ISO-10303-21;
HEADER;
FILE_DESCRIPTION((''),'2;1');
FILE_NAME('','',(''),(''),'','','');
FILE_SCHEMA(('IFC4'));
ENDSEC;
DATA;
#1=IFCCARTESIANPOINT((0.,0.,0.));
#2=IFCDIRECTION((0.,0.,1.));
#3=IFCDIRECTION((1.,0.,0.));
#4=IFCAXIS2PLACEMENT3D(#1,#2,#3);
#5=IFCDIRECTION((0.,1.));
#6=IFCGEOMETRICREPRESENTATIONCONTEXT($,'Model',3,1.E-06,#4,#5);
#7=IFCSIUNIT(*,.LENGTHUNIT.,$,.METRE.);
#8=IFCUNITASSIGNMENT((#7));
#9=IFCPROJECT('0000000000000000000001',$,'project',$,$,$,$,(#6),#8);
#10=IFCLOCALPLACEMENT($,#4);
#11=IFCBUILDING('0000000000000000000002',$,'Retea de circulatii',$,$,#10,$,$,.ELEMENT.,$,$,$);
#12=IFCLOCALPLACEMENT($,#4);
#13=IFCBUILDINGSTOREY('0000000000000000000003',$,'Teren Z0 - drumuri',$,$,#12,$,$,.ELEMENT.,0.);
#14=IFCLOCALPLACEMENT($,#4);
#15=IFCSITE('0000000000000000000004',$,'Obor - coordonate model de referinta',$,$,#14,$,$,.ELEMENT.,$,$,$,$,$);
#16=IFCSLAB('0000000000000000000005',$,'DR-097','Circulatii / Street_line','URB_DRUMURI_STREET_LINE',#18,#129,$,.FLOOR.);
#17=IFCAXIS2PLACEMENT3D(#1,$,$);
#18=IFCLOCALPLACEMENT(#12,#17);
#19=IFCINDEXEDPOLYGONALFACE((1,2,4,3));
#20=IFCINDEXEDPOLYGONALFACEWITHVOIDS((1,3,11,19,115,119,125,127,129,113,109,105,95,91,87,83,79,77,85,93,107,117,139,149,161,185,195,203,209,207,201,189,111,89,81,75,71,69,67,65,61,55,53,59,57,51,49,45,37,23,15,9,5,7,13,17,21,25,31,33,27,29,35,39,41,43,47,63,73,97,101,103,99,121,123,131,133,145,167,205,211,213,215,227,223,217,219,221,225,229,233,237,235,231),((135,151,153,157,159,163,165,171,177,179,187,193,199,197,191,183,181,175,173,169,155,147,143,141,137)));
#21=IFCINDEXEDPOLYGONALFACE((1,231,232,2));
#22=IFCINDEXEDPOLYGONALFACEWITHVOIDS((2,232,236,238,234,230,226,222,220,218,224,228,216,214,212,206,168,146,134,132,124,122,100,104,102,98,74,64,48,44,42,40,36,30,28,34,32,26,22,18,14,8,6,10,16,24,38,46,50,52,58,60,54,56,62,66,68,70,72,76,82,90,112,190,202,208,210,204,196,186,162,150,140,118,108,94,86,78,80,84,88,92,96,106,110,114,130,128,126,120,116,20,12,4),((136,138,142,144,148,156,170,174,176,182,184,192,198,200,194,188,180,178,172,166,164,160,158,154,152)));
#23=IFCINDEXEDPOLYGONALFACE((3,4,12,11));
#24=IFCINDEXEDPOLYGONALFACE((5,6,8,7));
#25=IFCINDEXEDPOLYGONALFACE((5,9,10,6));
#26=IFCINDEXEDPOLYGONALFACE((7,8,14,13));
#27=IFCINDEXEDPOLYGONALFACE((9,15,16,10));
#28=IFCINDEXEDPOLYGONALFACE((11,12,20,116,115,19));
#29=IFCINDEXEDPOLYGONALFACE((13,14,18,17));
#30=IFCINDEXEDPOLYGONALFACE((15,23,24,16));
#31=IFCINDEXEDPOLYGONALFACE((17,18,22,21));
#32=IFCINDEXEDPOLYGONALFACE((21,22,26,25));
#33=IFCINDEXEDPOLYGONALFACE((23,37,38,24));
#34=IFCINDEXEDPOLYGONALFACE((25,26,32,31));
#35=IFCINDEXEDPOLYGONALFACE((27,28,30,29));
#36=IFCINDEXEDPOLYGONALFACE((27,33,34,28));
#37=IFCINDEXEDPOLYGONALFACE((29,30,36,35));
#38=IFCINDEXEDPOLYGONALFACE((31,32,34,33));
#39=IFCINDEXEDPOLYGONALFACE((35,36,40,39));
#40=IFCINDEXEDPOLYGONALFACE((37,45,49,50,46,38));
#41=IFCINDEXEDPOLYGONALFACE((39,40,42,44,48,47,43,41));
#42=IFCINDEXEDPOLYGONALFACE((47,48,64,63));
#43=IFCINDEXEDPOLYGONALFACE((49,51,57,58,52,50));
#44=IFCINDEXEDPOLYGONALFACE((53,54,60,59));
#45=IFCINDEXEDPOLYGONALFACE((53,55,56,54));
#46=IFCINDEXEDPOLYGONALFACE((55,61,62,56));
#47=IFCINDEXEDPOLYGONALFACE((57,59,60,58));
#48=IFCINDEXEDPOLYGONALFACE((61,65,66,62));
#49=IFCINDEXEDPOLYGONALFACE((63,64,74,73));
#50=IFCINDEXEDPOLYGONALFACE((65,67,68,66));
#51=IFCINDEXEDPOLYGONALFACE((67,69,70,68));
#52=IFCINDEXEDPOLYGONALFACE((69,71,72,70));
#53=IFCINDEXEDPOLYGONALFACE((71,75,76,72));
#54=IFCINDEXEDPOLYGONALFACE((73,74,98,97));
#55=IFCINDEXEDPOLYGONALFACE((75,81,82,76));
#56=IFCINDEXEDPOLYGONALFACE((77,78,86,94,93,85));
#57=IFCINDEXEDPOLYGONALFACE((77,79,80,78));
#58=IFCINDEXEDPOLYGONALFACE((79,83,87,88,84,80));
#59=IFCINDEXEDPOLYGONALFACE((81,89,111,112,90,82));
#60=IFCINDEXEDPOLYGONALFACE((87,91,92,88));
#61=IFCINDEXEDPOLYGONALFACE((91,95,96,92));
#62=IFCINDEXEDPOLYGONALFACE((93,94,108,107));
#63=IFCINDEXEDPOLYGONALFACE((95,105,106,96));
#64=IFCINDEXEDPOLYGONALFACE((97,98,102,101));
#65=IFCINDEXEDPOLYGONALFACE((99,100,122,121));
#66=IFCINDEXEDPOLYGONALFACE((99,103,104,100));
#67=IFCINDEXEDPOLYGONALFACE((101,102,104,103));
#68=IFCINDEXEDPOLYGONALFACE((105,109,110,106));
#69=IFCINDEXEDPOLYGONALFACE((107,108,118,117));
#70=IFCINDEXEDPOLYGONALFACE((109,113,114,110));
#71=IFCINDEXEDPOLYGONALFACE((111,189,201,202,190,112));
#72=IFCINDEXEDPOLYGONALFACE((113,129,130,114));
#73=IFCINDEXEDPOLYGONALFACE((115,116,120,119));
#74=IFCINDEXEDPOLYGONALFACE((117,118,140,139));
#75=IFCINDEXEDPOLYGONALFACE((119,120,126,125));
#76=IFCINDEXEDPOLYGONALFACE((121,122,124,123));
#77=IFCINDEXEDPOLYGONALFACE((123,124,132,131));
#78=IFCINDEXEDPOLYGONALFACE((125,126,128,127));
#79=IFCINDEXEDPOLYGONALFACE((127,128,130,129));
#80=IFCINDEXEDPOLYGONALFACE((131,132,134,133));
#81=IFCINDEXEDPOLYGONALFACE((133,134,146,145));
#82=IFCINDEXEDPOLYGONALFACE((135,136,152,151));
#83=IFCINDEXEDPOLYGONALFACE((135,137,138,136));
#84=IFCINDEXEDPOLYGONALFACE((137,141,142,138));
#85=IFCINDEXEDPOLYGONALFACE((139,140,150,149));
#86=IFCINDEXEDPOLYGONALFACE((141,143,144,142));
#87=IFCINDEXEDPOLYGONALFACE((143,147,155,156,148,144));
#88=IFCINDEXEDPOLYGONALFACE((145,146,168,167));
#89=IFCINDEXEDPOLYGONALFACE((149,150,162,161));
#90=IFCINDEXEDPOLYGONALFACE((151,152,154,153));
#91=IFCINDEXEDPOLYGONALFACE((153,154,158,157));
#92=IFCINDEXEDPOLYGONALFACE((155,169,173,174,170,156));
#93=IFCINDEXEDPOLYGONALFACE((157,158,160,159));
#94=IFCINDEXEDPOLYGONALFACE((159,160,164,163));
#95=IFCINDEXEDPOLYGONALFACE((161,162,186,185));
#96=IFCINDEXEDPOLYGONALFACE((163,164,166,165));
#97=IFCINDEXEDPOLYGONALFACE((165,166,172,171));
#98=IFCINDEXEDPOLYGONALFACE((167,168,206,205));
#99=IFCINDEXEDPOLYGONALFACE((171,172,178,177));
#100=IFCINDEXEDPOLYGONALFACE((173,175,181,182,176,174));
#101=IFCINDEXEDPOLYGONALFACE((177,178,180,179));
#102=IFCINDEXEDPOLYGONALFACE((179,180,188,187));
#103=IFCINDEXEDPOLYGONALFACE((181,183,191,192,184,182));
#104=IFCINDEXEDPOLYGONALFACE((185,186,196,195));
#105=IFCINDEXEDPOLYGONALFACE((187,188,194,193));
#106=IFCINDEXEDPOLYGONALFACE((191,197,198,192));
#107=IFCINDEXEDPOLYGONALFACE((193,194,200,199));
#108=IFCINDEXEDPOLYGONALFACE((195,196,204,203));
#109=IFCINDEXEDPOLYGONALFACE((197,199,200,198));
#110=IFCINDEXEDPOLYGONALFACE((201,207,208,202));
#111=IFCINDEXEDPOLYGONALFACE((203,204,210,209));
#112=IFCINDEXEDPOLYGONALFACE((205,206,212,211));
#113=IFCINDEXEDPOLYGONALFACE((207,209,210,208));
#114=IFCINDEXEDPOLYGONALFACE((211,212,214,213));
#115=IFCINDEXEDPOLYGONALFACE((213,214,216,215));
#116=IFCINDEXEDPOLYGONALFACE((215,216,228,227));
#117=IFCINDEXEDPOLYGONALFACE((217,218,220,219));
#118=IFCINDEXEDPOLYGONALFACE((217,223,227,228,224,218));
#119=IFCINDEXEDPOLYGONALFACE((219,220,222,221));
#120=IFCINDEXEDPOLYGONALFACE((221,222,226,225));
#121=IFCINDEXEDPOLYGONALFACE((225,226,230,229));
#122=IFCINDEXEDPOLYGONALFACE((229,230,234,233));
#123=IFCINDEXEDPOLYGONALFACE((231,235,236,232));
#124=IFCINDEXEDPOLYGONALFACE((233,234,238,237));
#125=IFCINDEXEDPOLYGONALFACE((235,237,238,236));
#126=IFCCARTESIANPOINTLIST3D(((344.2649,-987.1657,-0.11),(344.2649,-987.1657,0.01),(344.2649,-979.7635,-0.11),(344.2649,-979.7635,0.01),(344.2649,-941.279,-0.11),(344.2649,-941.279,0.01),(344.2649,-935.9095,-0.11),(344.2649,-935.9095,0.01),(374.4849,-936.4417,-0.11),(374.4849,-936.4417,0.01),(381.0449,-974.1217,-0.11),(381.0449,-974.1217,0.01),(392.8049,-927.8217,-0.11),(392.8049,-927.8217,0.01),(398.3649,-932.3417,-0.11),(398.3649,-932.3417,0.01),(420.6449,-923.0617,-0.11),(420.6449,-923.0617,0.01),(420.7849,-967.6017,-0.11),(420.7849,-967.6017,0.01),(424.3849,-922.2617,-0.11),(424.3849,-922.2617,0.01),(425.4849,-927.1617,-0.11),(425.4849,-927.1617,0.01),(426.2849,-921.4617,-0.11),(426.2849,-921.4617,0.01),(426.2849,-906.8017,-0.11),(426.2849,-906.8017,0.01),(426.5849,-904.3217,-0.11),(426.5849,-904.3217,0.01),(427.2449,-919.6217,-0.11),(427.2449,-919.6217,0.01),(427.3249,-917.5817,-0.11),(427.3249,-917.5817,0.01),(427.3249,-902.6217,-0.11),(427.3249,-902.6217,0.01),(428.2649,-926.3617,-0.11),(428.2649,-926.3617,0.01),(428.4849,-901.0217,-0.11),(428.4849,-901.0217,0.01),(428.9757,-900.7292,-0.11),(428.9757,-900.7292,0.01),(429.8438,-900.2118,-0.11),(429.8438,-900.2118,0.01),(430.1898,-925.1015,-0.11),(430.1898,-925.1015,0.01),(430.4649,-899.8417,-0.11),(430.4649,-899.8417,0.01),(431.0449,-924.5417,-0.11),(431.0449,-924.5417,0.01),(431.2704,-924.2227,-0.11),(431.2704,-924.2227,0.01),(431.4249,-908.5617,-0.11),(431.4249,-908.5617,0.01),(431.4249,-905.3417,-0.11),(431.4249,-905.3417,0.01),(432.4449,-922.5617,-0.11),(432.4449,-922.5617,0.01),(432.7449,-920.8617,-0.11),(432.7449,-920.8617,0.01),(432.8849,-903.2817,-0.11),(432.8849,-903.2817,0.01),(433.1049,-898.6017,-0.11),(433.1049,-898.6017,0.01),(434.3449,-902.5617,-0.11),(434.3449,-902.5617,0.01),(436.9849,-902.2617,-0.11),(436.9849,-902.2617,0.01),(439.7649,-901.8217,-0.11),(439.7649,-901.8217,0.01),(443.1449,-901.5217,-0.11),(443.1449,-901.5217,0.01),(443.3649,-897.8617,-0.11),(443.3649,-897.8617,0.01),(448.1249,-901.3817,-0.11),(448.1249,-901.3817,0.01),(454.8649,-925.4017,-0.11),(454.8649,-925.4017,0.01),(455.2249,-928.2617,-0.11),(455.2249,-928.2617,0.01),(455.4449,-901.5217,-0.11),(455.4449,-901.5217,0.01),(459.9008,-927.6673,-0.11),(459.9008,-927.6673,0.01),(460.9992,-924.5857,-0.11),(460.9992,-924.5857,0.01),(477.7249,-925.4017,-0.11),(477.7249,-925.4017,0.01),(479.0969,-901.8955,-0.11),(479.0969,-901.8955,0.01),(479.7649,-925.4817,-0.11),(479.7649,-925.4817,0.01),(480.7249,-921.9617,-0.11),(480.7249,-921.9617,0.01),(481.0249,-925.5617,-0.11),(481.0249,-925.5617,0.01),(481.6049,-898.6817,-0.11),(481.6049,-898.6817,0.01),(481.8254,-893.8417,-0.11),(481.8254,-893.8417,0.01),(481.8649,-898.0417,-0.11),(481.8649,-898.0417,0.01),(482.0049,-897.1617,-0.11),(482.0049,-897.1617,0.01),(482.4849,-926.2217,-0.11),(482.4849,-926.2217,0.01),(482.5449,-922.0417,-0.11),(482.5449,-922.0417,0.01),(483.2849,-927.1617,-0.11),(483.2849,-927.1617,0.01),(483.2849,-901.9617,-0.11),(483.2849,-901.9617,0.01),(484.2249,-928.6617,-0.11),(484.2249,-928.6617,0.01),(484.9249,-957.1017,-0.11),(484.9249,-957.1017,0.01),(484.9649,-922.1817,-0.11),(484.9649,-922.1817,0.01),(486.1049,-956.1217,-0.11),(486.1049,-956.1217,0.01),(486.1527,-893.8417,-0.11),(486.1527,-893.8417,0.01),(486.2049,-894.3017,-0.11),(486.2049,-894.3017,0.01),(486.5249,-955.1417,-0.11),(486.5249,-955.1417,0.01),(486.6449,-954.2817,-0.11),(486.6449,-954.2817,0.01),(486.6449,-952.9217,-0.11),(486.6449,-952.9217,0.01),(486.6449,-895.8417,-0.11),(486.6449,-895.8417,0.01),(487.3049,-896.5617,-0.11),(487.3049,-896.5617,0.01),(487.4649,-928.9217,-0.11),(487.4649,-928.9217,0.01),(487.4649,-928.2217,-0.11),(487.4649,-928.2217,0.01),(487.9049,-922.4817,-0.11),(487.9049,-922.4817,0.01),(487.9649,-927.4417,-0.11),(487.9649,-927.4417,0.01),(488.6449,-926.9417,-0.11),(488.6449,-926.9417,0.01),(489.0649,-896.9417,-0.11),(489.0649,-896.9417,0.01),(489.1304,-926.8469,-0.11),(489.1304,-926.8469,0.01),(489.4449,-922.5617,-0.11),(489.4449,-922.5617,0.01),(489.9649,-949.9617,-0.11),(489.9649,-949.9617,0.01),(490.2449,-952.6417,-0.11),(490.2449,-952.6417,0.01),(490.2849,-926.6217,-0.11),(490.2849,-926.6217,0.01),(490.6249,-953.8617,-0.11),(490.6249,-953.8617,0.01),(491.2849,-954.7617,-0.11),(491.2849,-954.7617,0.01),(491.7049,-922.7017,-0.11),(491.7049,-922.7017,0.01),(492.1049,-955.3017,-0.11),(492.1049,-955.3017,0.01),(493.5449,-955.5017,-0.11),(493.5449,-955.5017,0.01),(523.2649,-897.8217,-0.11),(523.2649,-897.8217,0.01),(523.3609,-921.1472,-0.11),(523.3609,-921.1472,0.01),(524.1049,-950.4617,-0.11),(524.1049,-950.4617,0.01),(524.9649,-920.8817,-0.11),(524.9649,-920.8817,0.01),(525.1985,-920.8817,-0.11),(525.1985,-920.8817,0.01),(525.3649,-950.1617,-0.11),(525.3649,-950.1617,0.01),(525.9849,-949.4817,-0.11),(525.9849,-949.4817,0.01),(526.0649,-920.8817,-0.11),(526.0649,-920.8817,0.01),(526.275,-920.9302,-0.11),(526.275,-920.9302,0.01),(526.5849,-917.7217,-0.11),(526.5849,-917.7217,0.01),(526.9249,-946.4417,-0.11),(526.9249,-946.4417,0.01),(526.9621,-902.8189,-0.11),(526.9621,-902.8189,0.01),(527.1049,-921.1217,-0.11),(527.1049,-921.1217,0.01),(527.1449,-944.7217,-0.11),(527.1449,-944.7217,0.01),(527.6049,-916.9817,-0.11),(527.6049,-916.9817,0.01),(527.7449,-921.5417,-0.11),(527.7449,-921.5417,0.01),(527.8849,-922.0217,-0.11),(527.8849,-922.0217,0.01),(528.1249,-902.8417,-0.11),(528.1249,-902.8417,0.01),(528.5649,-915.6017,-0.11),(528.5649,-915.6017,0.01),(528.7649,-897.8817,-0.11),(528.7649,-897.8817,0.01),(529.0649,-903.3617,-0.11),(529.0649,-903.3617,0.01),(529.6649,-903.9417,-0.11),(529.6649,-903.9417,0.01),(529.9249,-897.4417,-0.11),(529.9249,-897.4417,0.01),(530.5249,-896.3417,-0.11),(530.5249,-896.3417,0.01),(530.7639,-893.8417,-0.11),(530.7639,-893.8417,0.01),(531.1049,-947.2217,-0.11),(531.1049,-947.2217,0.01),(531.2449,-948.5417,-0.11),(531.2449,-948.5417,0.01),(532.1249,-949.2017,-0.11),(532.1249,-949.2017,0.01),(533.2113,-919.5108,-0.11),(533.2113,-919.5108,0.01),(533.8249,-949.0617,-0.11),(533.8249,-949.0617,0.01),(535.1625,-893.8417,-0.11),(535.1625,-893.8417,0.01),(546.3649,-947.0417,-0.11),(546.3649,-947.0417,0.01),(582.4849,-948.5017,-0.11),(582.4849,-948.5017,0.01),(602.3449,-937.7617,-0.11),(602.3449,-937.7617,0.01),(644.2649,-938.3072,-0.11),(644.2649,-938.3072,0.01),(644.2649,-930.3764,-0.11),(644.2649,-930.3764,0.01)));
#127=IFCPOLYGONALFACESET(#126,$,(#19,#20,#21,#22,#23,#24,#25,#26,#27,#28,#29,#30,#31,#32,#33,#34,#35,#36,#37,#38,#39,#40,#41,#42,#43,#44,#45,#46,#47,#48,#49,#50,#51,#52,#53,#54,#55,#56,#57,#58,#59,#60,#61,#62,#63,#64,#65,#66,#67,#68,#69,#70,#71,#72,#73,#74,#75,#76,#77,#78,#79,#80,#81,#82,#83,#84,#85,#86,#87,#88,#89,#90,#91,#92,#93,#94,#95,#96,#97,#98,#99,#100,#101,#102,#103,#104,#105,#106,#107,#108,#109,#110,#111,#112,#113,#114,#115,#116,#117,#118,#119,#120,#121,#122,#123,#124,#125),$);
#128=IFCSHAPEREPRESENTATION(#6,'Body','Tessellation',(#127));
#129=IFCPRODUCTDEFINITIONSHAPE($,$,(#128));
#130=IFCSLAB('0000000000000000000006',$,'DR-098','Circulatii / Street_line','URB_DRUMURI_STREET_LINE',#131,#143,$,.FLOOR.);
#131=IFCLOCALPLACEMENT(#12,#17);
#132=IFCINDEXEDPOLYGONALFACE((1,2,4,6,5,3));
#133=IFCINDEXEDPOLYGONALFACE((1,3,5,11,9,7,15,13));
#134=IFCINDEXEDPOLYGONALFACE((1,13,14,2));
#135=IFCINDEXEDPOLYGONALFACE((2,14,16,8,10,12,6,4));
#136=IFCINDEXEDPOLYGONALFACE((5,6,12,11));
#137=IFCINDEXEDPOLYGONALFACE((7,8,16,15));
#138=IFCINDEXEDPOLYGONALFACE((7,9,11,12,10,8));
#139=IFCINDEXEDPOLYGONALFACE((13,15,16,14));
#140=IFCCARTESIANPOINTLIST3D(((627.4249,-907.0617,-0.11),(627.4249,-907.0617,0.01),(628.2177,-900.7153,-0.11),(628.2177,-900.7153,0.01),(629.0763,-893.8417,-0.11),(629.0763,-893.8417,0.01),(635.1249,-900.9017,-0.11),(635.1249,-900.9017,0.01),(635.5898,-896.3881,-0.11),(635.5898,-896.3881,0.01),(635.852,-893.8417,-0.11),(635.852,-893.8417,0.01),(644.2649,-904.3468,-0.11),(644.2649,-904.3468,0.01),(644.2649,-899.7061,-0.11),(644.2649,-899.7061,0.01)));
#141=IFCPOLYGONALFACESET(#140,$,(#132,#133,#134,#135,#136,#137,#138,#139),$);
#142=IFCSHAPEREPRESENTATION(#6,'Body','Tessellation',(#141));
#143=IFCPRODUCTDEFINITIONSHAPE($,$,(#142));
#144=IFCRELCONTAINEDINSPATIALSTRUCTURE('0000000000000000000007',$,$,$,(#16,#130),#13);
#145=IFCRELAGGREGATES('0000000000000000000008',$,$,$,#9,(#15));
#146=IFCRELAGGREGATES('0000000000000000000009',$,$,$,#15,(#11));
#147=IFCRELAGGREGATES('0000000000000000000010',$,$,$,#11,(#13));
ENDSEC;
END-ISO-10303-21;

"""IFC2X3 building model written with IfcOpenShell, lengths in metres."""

from ifc_helpers import new_model, si_unit, direction, frame, origin_with_axes, place, context, project, spatial, polyline, outline, extrude, element, save


model = new_model("IFC2X3")

# Units and contexts
model_context = context("Model", 3, precision=1e-06, world=origin_with_axes(), true_north=direction((0.0, 1.0)))
ifc_project = project(units=[si_unit("LENGTHUNIT", "METRE")], contexts=[model_context])

# Site, building, storey
site_placement = place(None, origin_with_axes())
site = spatial("IfcSite", under=ifc_project, at=site_placement, Name="Obor - coordonate model de referinta", CompositionType="ELEMENT")
building_placement = place(None, origin_with_axes())
building = spatial("IfcBuilding", under=site, at=building_placement, Name="Retea de circulatii", CompositionType="ELEMENT")
storey_placement = place(None, origin_with_axes())
storey = spatial("IfcBuildingStorey", under=building, at=storey_placement, Name="Teren Z0 - drumuri", CompositionType="ELEMENT", Elevation=0.0)

# Slabs
slab_1_placement = place(None, origin_with_axes())
element("IfcSlab", 1, at=slab_1_placement, inside=storey, Name="DR-097", Description="Circulatii / Street_line", ObjectType="URB_DRUMURI_STREET_LINE", PredefinedType="FLOOR", context=model_context, shape_type="SweptSolid", body=[
    extrude(outline(polyline([(344.2649, -979.7635), (344.2649, -987.1657), (582.4849, -948.5017), (644.2649, -938.3072), (644.2649, -930.3764), (602.3449, -937.7617), (546.3649, -947.0417), (533.8249, -949.0617), (532.1249, -949.2017), (531.2449, -948.5417), (531.1049, -947.2217), (533.2113, -919.5108), (535.1625, -893.8417), (530.7639, -893.8417), (530.5249, -896.3417), (529.9249, -897.4417), (528.7649, -897.8817), (523.2649, -897.8217), (489.0649, -896.9417), (487.3049, -896.5617), (486.6449, -895.8417), (486.2049, -894.3017), (486.1527, -893.8417), (481.8254, -893.8417), (482.0049, -897.1617), (481.8649, -898.0417), (481.6049, -898.6817), (443.3649, -897.8617), (433.1049, -898.6017), (430.4649, -899.8417), (429.8438, -900.2118), (428.9757, -900.7292), (428.4849, -901.0217), (427.3249, -902.6217), (426.5849, -904.3217), (426.2849, -906.8017), (427.3249, -917.5817), (427.2449, -919.6217), (426.2849, -921.4617), (424.3849, -922.2617), (420.6449, -923.0617), (392.8049, -927.8217), (344.2649, -935.9095), (344.2649, -941.279), (374.4849, -936.4417), (398.3649, -932.3417), (425.4849, -927.1617), (428.2649, -926.3617), (430.1898, -925.1015), (431.0449, -924.5417), (431.2704, -924.2227), (432.4449, -922.5617), (432.7449, -920.8617), (431.4249, -908.5617), (431.4249, -905.3417), (432.8849, -903.2817), (434.3449, -902.5617), (436.9849, -902.2617), (439.7649, -901.8217), (443.1449, -901.5217), (448.1249, -901.3817), (455.4449, -901.5217), (479.0969, -901.8955), (483.2849, -901.9617), (526.9621, -902.8189), (528.1249, -902.8417), (529.0649, -903.3617), (529.6649, -903.9417), (528.5649, -915.6017), (527.6049, -916.9817), (526.5849, -917.7217), (491.7049, -922.7017), (489.4449, -922.5617), (487.9049, -922.4817), (484.9649, -922.1817), (482.5449, -922.0417), (480.7249, -921.9617), (460.9992, -924.5857), (454.8649, -925.4017), (455.2249, -928.2617), (459.9008, -927.6673), (477.7249, -925.4017), (479.7649, -925.4817), (481.0249, -925.5617), (482.4849, -926.2217), (483.2849, -927.1617), (484.2249, -928.6617), (486.6449, -952.9217), (486.6449, -954.2817), (486.5249, -955.1417), (486.1049, -956.1217), (484.9249, -957.1017), (420.7849, -967.6017), (381.0449, -974.1217), (344.2649, -979.7635)]), holes=[polyline([(493.5449, -955.5017), (492.1049, -955.3017), (491.2849, -954.7617), (490.6249, -953.8617), (490.2449, -952.6417), (489.9649, -949.9617), (487.4649, -928.9217), (487.4649, -928.2217), (487.9649, -927.4417), (488.6449, -926.9417), (489.1304, -926.8469), (490.2849, -926.6217), (523.3609, -921.1472), (524.9649, -920.8817), (525.1985, -920.8817), (526.0649, -920.8817), (526.275, -920.9302), (527.1049, -921.1217), (527.7449, -921.5417), (527.8849, -922.0217), (527.1449, -944.7217), (526.9249, -946.4417), (525.9849, -949.4817), (525.3649, -950.1617), (524.1049, -950.4617), (493.5449, -955.5017)])]), frame((0.0, 0.0, -0.11), z_axis=(0.0, 0.0, 1.0), x_axis=(1.0, 0.0, 0.0)), (0.0, 0.0, 1.0), 0.12),
])
slab_2_placement = place(None, origin_with_axes())
element("IfcSlab", 2, at=slab_2_placement, inside=storey, Name="DR-098", Description="Circulatii / Street_line", ObjectType="URB_DRUMURI_STREET_LINE", PredefinedType="FLOOR", context=model_context, shape_type="SweptSolid", body=[
    extrude(outline(polyline([(629.0763, -893.8417), (628.2177, -900.7153), (627.4249, -907.0617), (644.2649, -904.3468), (644.2649, -899.7061), (635.1249, -900.9017), (635.5898, -896.3881), (635.852, -893.8417), (629.0763, -893.8417)])), frame((0.0, 0.0, -0.11), z_axis=(0.0, 0.0, 1.0), x_axis=(1.0, 0.0, 0.0)), (0.0, 0.0, 1.0), 0.12),
])

save(model, "model.ifc")
